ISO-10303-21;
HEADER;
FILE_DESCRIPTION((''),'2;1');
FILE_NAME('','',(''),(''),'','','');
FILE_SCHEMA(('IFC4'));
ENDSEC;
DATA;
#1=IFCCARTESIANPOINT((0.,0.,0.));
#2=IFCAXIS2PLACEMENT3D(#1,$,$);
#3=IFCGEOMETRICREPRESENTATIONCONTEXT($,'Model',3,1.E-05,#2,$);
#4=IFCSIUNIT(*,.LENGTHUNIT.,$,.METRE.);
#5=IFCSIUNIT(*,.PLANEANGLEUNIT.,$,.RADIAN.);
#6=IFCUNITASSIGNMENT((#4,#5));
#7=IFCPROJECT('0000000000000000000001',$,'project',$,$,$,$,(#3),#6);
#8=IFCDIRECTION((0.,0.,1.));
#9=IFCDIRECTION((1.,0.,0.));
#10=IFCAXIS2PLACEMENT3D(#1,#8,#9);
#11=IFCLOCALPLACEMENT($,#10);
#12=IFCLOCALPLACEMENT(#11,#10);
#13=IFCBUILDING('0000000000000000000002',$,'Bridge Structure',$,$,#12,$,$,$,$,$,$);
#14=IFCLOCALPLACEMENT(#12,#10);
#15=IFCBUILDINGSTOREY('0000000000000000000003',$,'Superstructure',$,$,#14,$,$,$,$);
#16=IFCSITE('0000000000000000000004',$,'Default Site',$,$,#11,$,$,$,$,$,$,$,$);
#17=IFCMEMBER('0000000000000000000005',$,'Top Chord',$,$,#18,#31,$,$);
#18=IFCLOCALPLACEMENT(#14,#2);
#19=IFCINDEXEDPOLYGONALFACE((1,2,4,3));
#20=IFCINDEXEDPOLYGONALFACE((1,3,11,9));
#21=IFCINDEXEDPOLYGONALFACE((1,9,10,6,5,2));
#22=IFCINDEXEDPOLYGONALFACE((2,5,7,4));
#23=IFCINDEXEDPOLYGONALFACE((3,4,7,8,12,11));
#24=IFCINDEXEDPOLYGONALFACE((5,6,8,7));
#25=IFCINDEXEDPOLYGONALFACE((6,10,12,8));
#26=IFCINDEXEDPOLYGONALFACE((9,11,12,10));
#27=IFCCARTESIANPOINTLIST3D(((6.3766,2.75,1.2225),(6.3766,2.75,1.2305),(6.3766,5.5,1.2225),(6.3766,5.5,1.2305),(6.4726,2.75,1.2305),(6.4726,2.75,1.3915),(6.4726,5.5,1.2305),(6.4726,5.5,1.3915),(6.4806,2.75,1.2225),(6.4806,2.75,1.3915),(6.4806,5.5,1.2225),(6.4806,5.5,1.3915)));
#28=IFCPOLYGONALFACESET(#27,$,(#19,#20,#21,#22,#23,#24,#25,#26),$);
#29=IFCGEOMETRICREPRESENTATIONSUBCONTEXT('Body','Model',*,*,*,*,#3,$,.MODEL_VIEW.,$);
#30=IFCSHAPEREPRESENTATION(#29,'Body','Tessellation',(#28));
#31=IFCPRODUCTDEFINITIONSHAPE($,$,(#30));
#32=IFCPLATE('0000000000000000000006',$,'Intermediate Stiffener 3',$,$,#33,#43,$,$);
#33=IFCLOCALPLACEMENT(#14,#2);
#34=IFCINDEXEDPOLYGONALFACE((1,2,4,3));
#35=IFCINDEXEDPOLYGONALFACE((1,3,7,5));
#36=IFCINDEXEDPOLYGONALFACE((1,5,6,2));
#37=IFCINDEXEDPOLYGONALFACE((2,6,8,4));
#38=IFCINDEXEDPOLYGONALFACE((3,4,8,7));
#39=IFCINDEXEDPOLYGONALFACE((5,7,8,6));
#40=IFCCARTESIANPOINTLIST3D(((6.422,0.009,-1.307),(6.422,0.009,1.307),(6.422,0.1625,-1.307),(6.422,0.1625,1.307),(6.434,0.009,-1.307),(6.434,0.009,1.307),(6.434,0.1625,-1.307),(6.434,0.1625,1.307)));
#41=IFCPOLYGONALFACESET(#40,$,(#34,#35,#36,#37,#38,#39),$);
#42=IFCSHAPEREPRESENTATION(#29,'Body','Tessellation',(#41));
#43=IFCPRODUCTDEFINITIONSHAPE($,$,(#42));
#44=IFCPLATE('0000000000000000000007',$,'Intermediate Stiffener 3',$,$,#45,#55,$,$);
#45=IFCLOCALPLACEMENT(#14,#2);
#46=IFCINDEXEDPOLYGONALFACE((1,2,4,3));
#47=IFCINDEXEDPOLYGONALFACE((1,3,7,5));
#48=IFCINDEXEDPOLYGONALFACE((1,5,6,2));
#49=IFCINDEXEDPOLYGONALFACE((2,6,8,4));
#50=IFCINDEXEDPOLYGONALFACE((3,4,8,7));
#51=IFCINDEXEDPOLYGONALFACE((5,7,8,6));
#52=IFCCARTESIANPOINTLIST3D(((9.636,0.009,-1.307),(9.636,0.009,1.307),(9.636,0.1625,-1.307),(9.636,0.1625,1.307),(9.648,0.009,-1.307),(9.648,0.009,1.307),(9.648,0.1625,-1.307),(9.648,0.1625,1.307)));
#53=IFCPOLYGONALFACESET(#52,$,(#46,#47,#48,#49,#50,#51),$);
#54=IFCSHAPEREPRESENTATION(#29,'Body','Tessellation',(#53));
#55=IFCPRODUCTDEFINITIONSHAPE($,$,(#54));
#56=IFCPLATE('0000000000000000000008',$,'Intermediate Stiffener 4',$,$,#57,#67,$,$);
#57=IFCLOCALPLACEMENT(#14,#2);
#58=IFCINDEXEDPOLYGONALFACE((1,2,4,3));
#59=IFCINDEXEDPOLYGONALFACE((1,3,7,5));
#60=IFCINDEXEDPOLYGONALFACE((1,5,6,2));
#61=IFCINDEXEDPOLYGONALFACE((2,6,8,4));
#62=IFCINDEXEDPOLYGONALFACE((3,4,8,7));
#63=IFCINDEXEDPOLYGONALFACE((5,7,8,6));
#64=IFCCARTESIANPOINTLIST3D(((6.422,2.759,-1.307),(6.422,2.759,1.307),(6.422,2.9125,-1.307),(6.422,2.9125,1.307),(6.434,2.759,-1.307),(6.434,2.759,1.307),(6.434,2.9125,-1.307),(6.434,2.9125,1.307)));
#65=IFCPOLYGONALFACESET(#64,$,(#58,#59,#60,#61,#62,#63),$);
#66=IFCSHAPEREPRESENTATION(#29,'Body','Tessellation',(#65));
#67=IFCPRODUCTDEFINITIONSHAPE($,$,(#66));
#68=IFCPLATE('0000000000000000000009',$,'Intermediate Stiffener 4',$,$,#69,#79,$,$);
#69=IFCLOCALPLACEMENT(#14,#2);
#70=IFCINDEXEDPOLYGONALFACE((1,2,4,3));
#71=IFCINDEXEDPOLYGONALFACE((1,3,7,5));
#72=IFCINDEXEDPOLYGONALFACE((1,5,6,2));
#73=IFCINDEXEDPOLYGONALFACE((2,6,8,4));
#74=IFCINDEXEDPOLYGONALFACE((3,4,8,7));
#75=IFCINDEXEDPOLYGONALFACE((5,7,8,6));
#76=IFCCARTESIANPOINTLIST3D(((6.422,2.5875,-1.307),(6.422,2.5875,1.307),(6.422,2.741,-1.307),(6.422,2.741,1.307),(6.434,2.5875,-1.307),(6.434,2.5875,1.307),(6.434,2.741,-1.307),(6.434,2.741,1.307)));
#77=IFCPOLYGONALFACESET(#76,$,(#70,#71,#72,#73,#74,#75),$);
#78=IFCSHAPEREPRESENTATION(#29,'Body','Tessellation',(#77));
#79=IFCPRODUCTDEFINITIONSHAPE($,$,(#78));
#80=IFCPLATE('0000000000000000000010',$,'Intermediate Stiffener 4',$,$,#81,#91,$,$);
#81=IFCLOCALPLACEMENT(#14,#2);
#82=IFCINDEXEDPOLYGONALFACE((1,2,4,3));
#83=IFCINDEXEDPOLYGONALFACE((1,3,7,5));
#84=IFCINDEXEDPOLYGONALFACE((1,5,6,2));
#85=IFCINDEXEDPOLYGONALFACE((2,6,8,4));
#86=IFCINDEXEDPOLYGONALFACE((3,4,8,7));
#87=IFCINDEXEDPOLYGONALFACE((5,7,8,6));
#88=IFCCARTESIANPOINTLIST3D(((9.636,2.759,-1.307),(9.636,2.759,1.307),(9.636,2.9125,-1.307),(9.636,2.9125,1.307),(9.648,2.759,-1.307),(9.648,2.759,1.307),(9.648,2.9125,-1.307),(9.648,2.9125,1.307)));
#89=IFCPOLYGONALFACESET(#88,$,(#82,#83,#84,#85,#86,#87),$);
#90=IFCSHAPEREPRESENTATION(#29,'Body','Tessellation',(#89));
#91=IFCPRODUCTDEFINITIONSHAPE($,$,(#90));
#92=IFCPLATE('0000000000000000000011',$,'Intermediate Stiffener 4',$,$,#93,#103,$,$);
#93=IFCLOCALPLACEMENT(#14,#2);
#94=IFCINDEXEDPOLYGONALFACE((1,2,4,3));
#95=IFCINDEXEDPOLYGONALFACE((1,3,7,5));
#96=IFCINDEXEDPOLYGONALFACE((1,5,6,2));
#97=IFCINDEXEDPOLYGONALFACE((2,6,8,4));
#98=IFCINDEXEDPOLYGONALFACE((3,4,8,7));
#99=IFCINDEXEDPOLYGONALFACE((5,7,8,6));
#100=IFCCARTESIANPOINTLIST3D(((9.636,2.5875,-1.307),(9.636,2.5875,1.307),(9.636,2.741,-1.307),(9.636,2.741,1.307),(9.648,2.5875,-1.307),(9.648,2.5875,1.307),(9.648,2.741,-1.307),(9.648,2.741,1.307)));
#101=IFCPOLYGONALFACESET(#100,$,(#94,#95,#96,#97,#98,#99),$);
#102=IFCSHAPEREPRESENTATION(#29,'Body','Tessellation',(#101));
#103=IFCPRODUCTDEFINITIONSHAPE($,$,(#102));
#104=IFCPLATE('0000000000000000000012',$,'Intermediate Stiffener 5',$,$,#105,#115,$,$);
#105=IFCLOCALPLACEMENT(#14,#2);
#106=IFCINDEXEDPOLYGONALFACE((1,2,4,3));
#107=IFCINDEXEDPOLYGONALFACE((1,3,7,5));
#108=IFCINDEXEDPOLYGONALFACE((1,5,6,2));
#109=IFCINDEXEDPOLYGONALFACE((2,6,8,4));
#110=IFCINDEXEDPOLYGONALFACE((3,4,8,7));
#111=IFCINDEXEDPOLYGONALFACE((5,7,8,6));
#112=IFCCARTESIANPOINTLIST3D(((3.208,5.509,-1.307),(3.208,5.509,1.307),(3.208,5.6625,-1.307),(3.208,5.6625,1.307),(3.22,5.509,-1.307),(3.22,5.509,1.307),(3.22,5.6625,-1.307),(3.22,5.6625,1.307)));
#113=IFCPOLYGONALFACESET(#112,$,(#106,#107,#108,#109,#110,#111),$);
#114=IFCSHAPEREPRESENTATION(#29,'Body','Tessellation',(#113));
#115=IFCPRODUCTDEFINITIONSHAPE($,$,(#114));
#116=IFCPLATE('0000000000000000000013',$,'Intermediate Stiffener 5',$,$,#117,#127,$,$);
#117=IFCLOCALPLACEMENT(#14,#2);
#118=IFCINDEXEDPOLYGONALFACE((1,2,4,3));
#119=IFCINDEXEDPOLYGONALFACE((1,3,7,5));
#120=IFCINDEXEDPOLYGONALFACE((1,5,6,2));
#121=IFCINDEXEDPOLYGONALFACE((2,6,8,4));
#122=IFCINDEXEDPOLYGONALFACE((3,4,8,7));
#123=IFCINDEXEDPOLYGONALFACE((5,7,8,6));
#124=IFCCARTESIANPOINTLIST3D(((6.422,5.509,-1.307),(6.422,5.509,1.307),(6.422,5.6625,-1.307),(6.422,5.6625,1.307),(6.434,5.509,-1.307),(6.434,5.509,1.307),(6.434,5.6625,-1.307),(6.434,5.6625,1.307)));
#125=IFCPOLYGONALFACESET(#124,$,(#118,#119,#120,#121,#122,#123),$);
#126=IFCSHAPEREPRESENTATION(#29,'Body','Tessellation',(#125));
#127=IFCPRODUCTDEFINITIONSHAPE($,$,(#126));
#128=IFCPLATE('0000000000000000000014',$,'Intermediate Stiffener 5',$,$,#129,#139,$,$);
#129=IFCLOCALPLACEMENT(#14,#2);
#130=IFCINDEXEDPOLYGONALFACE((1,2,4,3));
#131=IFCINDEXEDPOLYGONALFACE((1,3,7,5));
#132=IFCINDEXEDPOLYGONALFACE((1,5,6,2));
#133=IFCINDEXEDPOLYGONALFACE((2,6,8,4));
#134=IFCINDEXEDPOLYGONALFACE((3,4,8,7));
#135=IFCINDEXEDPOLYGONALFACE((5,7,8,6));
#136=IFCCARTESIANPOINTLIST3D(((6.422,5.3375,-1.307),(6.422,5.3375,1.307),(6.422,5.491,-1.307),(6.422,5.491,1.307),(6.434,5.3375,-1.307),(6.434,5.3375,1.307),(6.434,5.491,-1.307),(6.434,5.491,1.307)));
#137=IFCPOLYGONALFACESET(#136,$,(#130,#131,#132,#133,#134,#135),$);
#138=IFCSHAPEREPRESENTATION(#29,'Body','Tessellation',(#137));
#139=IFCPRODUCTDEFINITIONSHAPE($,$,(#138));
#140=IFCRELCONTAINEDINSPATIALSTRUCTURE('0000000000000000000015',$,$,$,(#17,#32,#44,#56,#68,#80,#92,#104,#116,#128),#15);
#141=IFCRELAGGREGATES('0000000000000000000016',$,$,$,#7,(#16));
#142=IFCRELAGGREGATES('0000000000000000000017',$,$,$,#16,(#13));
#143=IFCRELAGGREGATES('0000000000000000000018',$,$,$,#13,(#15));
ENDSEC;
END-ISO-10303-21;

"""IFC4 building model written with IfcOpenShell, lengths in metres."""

from ifc_helpers import new_model, si_unit, frame, origin, origin_with_axes, origin_2d_with_axis, place, context, subcontext, project, spatial, rectangle, l_section, extrude, element, save


model = new_model("IFC4")

# Units and contexts
model_context = context("Model", 3, precision=1e-05, world=origin())
body_context = subcontext(model_context, "Body", "Model", "MODEL_VIEW")
ifc_project = project(units=[si_unit("LENGTHUNIT", "METRE"), si_unit("PLANEANGLEUNIT", "RADIAN")], contexts=[model_context])

# Site, building, storey
site_placement = place(None, origin_with_axes())
site = spatial("IfcSite", under=ifc_project, at=site_placement, Name="Default Site")
building_placement = place(site_placement, origin_with_axes())
building = spatial("IfcBuilding", under=site, at=building_placement, Name="Bridge Structure")
storey_placement = place(building_placement, origin_with_axes())
storey = spatial("IfcBuildingStorey", under=building, at=storey_placement, Name="Superstructure")

# Member
for number, where, z_axis, x_axis, name in (
    (1, (6.4286, 2.75, 1.307), (0.0, 1.0, 0.0), (-1.0, 0.0, 0.0), "Top Chord"),
):
    element("IfcMember", number, at=place(storey_placement, frame(where, z_axis=z_axis, x_axis=x_axis)), inside=storey, Name=name, context=body_context, shape_type="SweptSolid", body=[
        extrude(l_section(Depth=0.169, Width=0.104, Thickness=0.008, at=origin_2d_with_axis()), origin_with_axes(), (0.0, 0.0, 1.0), 2.75),
    ])

# Plates
for number, where, z_axis, x_axis, name in (
    (2, (6.428, 0.0858, -1.307), (0.0, 0.0, 1.0), (1.0, 0.0, 0.0), "Intermediate Stiffener 3"),
    (3, (9.642, 0.0858, -1.307), (0.0, 0.0, 1.0), (1.0, 0.0, 0.0), "Intermediate Stiffener 3"),
    (4, (6.428, 2.8357, -1.307), (0.0, 0.0, 1.0), (1.0, 0.0, 0.0), "Intermediate Stiffener 4"),
    (5, (6.428, 2.6643, -1.307), (0.0, 0.0, 1.0), (1.0, 0.0, 0.0), "Intermediate Stiffener 4"),
    (6, (9.642, 2.8357, -1.307), (0.0, 0.0, 1.0), (1.0, 0.0, 0.0), "Intermediate Stiffener 4"),
    (7, (9.642, 2.6643, -1.307), (0.0, 0.0, 1.0), (1.0, 0.0, 0.0), "Intermediate Stiffener 4"),
    (8, (3.214, 5.5857, -1.307), (0.0, 0.0, 1.0), (1.0, 0.0, 0.0), "Intermediate Stiffener 5"),
    (9, (6.428, 5.5857, -1.307), (0.0, 0.0, 1.0), (1.0, 0.0, 0.0), "Intermediate Stiffener 5"),
    (10, (6.428, 5.4143, -1.307), (0.0, 0.0, 1.0), (1.0, 0.0, 0.0), "Intermediate Stiffener 5"),
):
    element("IfcPlate", number, at=place(storey_placement, frame(where, z_axis=z_axis, x_axis=x_axis)), inside=storey, Name=name, context=body_context, shape_type="SweptSolid", body=[
        extrude(rectangle(XDim=0.012, YDim=0.1535, at=origin_2d_with_axis()), origin_with_axes(), (0.0, 0.0, 1.0), 2.614),
    ])

save(model, "model.ifc")
